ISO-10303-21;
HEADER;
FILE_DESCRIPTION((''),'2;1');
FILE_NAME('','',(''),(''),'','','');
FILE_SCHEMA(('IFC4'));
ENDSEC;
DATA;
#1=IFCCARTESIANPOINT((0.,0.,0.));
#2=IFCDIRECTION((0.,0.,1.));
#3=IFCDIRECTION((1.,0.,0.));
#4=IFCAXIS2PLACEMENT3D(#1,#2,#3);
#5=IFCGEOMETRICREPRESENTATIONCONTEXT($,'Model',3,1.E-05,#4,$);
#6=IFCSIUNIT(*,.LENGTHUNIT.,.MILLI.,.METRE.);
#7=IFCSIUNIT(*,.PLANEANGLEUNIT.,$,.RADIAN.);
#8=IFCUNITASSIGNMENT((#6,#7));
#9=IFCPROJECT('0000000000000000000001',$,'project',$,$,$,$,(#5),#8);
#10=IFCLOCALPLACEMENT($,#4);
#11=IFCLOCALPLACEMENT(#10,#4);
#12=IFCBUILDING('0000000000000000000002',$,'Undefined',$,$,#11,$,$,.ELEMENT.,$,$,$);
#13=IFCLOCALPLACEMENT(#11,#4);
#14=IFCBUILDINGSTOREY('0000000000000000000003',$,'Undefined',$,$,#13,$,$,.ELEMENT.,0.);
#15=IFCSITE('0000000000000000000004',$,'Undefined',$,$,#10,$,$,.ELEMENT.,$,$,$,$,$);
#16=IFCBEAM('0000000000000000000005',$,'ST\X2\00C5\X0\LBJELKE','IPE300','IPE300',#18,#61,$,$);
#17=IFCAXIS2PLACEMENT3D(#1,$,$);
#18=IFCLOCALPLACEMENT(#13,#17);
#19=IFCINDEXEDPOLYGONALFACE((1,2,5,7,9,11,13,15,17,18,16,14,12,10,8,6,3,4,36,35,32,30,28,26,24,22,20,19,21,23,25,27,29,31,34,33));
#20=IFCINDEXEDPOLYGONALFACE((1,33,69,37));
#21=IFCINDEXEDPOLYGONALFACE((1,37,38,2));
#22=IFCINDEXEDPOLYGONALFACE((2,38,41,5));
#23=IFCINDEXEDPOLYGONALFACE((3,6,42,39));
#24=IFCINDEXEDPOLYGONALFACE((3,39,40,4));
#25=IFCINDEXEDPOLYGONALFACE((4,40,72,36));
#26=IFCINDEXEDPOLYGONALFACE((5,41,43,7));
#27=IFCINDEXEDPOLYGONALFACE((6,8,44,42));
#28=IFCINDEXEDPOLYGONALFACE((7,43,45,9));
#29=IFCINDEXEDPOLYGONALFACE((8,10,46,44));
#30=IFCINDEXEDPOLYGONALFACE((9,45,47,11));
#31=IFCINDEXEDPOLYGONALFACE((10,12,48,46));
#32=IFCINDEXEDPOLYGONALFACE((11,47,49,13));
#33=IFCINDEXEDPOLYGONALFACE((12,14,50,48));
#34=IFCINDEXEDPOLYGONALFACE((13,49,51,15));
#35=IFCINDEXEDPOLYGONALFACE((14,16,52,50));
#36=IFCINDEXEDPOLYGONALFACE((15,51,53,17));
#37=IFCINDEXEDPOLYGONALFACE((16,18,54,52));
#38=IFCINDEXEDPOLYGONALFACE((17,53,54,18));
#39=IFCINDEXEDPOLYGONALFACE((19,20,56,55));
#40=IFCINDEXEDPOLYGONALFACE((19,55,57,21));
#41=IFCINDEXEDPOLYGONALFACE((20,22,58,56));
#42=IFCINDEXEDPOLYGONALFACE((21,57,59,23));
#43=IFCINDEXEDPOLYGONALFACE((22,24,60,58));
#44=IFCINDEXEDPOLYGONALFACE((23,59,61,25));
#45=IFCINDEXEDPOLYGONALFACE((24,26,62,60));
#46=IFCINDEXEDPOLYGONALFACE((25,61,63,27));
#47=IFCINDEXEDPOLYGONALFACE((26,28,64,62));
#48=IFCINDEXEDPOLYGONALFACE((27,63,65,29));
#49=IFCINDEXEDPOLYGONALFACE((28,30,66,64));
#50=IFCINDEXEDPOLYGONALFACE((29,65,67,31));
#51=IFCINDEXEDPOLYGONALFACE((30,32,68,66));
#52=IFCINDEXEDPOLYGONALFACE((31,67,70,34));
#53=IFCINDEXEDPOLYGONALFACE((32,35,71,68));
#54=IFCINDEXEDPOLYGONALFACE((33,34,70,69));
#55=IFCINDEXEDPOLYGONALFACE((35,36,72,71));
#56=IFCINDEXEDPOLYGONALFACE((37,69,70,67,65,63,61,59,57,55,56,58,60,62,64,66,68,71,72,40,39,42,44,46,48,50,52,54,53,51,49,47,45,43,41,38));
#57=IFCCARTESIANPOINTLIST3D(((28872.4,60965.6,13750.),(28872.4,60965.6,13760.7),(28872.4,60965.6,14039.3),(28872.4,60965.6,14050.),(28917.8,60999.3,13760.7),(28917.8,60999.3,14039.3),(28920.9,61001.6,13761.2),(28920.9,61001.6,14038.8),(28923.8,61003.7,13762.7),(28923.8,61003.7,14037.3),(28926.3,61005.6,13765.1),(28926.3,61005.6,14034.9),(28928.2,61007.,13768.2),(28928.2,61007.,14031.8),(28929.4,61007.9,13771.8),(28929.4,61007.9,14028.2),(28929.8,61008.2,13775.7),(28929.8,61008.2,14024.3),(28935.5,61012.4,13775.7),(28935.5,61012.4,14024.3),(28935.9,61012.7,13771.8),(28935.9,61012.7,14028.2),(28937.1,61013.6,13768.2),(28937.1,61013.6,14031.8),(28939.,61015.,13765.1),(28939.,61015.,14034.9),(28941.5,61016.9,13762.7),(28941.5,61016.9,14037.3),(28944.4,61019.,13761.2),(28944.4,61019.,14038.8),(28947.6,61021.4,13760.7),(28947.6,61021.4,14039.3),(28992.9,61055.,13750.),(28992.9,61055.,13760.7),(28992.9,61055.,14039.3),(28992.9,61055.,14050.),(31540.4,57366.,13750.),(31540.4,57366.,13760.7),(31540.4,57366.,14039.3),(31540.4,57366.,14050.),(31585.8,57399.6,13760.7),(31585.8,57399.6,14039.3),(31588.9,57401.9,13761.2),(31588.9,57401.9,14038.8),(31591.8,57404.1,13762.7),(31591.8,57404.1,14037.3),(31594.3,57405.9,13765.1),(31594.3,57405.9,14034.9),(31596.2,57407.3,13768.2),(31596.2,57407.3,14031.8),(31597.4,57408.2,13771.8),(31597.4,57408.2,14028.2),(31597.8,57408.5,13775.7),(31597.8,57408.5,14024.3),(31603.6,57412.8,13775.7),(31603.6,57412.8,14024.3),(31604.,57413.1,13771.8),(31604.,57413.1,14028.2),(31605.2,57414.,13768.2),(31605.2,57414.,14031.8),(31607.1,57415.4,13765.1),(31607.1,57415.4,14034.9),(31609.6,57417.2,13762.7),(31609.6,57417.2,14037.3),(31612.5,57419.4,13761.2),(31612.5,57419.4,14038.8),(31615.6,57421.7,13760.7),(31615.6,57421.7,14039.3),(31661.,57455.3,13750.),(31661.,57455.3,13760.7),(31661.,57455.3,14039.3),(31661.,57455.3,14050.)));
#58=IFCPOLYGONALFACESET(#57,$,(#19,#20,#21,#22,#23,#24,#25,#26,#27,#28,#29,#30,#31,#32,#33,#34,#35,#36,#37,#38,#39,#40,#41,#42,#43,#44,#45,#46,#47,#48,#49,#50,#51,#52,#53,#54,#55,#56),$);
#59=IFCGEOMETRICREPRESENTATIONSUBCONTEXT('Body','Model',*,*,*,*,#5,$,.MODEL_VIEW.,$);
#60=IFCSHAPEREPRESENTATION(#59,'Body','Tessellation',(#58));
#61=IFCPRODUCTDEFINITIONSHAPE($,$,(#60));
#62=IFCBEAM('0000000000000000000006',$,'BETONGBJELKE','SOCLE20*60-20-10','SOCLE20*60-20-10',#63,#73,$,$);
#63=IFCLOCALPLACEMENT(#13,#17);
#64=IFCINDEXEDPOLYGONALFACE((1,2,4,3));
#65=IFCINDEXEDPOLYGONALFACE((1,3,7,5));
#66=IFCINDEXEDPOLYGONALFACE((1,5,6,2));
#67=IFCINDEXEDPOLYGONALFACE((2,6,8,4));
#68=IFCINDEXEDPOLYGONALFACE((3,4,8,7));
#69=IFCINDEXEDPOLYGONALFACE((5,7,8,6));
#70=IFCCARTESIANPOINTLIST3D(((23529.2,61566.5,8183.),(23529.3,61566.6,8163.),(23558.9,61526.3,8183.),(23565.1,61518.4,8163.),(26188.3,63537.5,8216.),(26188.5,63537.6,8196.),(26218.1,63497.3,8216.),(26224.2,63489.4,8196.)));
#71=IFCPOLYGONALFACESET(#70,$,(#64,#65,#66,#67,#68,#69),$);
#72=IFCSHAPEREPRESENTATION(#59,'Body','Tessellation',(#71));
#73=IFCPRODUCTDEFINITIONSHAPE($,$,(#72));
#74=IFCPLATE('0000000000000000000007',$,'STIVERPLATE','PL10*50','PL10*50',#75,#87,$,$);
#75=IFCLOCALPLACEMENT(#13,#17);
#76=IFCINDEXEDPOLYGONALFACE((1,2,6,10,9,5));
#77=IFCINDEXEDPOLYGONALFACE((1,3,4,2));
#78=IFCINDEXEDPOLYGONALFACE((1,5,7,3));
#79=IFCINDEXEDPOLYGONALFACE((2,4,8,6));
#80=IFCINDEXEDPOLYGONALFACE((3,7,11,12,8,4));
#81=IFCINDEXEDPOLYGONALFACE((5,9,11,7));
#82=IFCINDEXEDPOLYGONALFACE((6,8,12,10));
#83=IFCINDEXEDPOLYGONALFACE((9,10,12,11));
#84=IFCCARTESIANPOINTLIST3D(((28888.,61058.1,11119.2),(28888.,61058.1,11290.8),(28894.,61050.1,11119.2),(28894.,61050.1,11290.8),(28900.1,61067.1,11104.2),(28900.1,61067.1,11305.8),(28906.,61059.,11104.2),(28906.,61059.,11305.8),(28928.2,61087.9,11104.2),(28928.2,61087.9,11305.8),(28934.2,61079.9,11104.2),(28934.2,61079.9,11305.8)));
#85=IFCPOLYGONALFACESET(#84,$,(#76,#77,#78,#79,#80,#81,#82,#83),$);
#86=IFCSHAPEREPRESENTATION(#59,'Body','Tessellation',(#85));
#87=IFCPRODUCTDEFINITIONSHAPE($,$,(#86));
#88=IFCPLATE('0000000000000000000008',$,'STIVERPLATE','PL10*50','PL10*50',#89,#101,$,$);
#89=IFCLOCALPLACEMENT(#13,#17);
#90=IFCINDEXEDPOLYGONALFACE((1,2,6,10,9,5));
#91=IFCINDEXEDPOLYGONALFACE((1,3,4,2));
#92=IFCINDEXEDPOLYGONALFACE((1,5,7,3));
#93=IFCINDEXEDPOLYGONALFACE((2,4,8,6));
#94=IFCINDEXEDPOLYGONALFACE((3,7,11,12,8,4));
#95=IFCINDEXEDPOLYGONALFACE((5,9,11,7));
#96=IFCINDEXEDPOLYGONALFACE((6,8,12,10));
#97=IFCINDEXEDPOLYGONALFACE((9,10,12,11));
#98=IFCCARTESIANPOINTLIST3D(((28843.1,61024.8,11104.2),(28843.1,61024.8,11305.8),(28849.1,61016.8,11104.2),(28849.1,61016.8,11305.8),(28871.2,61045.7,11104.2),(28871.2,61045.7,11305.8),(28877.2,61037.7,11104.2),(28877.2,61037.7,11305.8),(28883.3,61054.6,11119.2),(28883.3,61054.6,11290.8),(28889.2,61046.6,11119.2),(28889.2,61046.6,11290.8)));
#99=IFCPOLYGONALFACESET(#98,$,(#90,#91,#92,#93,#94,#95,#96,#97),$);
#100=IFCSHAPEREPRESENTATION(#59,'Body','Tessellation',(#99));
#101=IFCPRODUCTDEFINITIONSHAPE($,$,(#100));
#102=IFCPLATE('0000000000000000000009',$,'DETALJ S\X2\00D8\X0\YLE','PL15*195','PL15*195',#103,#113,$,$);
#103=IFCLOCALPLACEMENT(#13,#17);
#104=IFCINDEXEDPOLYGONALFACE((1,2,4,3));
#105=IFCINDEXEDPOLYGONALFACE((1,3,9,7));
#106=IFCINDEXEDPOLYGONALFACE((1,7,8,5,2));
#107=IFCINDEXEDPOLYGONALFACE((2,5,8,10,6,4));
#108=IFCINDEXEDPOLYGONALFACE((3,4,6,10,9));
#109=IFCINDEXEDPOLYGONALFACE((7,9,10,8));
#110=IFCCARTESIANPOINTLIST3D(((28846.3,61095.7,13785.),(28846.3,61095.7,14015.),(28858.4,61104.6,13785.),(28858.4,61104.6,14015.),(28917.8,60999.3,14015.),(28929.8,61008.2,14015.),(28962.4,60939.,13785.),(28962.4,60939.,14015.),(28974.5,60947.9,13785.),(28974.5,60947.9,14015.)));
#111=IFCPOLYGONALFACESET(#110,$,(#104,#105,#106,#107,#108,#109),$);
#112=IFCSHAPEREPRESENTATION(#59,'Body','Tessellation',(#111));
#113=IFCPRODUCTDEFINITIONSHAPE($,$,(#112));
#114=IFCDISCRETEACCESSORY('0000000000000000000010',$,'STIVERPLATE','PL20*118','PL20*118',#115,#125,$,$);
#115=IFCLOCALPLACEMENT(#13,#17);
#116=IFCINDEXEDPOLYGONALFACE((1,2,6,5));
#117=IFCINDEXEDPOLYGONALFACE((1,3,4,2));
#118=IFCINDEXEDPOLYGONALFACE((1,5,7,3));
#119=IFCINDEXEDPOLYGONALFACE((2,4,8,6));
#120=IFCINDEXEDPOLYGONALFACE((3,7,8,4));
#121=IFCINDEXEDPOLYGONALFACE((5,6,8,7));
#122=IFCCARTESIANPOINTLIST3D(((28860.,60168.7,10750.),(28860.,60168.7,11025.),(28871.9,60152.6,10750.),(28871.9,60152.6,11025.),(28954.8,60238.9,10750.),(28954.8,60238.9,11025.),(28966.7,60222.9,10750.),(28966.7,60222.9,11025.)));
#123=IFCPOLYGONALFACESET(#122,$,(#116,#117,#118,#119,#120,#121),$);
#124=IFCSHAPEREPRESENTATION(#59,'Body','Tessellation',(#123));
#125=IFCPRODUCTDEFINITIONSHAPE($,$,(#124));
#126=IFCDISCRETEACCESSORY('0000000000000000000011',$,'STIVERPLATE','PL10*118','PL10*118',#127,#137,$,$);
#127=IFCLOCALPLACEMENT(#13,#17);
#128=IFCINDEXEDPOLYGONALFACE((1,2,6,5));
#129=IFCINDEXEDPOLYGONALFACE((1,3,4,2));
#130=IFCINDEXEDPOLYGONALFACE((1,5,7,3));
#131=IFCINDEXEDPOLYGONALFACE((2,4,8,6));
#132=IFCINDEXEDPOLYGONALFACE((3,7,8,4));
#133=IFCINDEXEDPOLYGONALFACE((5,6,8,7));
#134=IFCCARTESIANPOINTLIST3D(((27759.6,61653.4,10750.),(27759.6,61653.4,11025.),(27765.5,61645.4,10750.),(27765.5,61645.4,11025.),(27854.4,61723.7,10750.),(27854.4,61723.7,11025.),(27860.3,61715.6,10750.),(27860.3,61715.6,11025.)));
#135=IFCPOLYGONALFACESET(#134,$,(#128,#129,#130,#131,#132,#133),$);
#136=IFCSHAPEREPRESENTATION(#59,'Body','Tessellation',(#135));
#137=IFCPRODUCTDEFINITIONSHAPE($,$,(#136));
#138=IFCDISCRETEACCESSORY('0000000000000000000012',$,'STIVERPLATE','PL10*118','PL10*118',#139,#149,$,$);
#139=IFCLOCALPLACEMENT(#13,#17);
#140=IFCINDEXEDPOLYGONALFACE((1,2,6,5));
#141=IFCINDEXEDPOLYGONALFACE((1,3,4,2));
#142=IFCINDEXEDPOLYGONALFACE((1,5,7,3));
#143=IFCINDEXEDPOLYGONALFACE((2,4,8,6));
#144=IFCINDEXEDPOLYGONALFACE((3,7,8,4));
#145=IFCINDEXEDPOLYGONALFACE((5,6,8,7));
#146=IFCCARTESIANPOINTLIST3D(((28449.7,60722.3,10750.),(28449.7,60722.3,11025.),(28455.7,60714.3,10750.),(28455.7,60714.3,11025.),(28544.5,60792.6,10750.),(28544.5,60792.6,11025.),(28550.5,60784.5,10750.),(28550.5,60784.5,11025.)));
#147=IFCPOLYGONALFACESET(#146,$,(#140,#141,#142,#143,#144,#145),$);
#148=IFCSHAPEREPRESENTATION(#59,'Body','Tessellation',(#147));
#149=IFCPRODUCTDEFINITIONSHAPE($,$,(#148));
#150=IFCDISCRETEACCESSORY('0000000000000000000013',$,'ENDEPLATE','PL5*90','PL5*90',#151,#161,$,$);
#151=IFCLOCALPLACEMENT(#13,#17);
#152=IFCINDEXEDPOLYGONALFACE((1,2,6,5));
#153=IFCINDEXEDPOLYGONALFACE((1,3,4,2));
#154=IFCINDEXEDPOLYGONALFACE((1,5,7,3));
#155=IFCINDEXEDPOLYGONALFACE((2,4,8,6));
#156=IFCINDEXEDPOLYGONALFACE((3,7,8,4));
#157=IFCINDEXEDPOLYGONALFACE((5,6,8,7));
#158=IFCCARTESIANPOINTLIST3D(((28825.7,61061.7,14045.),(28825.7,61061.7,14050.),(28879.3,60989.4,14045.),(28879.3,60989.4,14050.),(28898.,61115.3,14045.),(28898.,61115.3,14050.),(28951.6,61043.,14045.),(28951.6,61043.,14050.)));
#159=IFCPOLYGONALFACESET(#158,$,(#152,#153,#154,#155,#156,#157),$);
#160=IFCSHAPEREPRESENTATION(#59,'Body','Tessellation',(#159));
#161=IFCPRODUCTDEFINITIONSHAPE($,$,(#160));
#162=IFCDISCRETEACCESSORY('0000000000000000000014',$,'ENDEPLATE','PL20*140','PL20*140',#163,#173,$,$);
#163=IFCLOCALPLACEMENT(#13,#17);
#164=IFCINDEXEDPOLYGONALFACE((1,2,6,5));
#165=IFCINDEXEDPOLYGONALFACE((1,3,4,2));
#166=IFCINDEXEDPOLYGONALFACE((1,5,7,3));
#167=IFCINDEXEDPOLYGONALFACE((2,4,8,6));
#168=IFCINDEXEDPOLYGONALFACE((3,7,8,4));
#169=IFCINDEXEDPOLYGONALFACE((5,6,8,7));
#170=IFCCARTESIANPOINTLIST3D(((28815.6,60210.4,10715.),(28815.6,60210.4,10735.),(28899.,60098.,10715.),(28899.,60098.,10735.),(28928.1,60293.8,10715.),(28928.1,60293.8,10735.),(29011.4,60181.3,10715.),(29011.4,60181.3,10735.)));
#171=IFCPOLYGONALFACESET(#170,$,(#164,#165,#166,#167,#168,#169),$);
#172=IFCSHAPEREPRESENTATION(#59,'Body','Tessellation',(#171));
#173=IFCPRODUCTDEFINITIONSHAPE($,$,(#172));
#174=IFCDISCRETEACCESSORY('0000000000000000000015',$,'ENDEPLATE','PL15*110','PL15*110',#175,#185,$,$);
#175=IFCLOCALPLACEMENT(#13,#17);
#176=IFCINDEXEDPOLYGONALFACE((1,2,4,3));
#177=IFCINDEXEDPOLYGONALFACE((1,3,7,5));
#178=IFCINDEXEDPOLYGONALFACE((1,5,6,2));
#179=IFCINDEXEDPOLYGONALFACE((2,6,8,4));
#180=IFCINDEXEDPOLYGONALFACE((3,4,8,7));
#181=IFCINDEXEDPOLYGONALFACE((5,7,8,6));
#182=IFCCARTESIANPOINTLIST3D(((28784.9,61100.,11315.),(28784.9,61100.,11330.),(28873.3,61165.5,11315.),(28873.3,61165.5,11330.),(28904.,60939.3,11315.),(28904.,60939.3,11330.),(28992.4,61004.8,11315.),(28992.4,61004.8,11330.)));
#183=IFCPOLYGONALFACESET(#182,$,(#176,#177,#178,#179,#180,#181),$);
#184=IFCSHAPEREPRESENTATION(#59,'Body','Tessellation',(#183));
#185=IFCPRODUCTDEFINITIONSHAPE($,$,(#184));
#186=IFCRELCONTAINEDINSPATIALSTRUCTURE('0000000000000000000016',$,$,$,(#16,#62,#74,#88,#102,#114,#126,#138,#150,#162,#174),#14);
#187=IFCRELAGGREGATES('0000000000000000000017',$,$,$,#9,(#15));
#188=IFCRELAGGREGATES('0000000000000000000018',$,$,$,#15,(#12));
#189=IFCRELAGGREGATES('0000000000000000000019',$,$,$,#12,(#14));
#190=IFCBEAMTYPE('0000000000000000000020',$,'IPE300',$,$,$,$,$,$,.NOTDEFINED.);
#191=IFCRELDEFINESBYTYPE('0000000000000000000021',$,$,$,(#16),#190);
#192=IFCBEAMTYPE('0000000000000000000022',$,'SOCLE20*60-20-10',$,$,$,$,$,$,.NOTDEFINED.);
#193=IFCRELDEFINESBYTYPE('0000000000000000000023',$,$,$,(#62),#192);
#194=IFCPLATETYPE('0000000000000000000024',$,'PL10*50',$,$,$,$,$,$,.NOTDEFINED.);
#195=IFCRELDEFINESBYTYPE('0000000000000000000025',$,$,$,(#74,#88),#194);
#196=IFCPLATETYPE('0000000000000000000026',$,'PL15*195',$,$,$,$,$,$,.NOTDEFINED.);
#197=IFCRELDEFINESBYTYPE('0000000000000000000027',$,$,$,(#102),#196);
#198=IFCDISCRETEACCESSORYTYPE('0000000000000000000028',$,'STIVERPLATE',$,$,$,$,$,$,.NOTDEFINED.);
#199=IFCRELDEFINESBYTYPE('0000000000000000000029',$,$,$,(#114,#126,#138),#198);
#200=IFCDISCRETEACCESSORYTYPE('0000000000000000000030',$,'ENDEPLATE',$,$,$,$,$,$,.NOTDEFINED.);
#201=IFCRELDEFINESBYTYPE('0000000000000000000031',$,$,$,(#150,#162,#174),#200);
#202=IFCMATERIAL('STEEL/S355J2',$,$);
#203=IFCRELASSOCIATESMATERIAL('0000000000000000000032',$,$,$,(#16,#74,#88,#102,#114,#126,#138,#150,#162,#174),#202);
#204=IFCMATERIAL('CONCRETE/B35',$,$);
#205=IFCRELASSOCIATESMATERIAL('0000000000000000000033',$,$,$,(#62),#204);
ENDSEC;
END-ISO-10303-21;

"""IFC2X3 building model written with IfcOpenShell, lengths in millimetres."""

from ifc_helpers import new_model, si_unit, frame, origin_with_axes, origin_2d_with_axis, place, context, subcontext, project, spatial, polyline, i_section, outline, extrude, clip, halfspace, material, type_object, element, save


model = new_model("IFC2X3")

# Units and contexts
model_context = context("Model", 3, precision=1e-05, world=origin_with_axes())
body_context = subcontext(model_context, "Body", "Model", "MODEL_VIEW")
ifc_project = project(units=[si_unit("LENGTHUNIT", "METRE", prefix="MILLI"), si_unit("PLANEANGLEUNIT", "RADIAN")], contexts=[model_context])

# Site, building, storey
site_placement = place(None, origin_with_axes())
site = spatial("IfcSite", under=ifc_project, at=site_placement, Name="Undefined", CompositionType="ELEMENT")
building_placement = place(site_placement, origin_with_axes())
building = spatial("IfcBuilding", under=site, at=building_placement, Name="Undefined", CompositionType="ELEMENT")
storey_placement = place(building_placement, origin_with_axes())
storey = spatial("IfcBuildingStorey", under=building, at=storey_placement, Name="Undefined", CompositionType="ELEMENT", Elevation=0.0)

# Shared definitions
ifc_material_1 = material(Name="STEEL/S355J2")

# Beams
beam_type_1 = type_object("IfcBeamType", Name="IPE300", PredefinedType="NOTDEFINED")
beam_1_placement = place(storey_placement, frame((28926.7, 61018.3, 13900.0), z_axis=(0.0, 0.0, 1.0), x_axis=(0.595461, -0.803384, 0.0)))
element("IfcBeam", 1, at=beam_1_placement, inside=storey, type_object=beam_type_1, material=ifc_material_1, Name="STÅLBJELKE", Description="IPE300", ObjectType="IPE300", context=body_context, shape_type="Clipping", body=[
    clip(clip(extrude(i_section(OverallWidth=150.0, OverallDepth=300.0, WebThickness=7.1, FlangeThickness=10.7, FilletRadius=15.0, at=origin_2d_with_axis()), frame((4635.6, 0.0, 0.0), z_axis=(-1.0, 0.0, 0.0), x_axis=(0.0, -1.0, 0.0)), (0.0, 0.0, 1.0), 4770.5), halfspace(frame((4490.6, 0.0, 250.0), z_axis=(1.0, -0.00002, 0.0), x_axis=(0.00002, 1.0, 0.0)), False)), halfspace(frame((10.0, 0.0, 250.0), z_axis=(-1.0, 0.00002, 0.0), x_axis=(-0.00002, -1.0, 0.0)), False)),
])
ifc_material_2 = material(Name="CONCRETE/B35")
beam_type_2 = type_object("IfcBeamType", Name="SOCLE20*60-20-10", PredefinedType="NOTDEFINED")
beam_2_placement = place(storey_placement, frame((23547.1, 61542.4, 8173.0), z_axis=(-0.008009, -0.005937, 0.99995), x_axis=(0.803328, 0.595453, 0.009969)))
element("IfcBeam", 2, at=beam_2_placement, inside=storey, type_object=beam_type_2, material=ifc_material_2, Name="BETONGBJELKE", Description="SOCLE20*60-20-10", ObjectType="SOCLE20*60-20-10", context=body_context, shape_type="SweptSolid", body=[
    extrude(outline(polyline([(30.0, -10.0), (-30.0, -10.0), (-30.0, 10.0), (20.0, 10.0), (30.0, -10.0)])), frame((3310.2, 0.0, 0.0), z_axis=(-1.0, 0.0, 0.0), x_axis=(0.0, -1.0, 0.0)), (0.0, 0.0, 1.0), 3310.2),
])

# Plates
plate_type_1 = type_object("IfcPlateType", Name="PL10*50", PredefinedType="NOTDEFINED")
plate_1_placement = place(storey_placement, frame((28931.2, 61083.9, 11104.2), z_axis=(-0.595472, 0.803376, 0.0), x_axis=(-0.803376, -0.595472, 0.0)))
element("IfcPlate", 3, at=plate_1_placement, inside=storey, type_object=plate_type_1, material=ifc_material_1, Name="STIVERPLATE", Description="PL10*50", ObjectType="PL10*50", context=body_context, shape_type="SweptSolid", body=[
    extrude(outline(polyline([(0.0, 0.0), (35.0, 0.0), (50.0, 15.0), (50.0, 186.6), (35.0, 201.6), (0.0, 201.6), (0.0, 0.0)])), frame((0.0, 0.0, -5.0), z_axis=(0.0, 0.0, 1.0), x_axis=(1.0, 0.0, 0.0)), (0.0, 0.0, 1.0), 10.0),
])
plate_2_placement = place(storey_placement, frame((28886.3, 61050.6, 11104.2), z_axis=(-0.595472, 0.803376, 0.0), x_axis=(-0.803376, -0.595472, 0.0)))
element("IfcPlate", 4, at=plate_2_placement, inside=storey, type_object=plate_type_1, material=ifc_material_1, Name="STIVERPLATE", Description="PL10*50", ObjectType="PL10*50", context=body_context, shape_type="SweptSolid", body=[
    extrude(outline(polyline([(0.0, 15.0), (15.0, 0.0), (50.0, 0.0), (50.0, 201.6), (15.0, 201.6), (0.0, 186.6), (0.0, 15.0)])), frame((0.0, 0.0, -5.0), z_axis=(0.0, 0.0, 1.0), x_axis=(1.0, 0.0, 0.0)), (0.0, 0.0, 1.0), 10.0),
])
plate_type_2 = type_object("IfcPlateType", Name="PL15*195", PredefinedType="NOTDEFINED")
plate_3_placement = place(storey_placement, frame((28923.8, 61003.7, 14015.0), z_axis=(-0.803384, -0.595461, 0.0), x_axis=(-0.595461, 0.803384, 0.0)))
element("IfcPlate", 5, at=plate_3_placement, inside=storey, type_object=plate_type_2, material=ifc_material_1, Name="DETALJ SØYLE", Description="PL15*195", ObjectType="PL15*195", context=body_context, shape_type="SweptSolid", body=[
    extrude(outline(polyline([(0.0, 0.0), (120.0, 0.0), (120.0, 230.0), (-75.0, 230.0), (-75.0, 0.0), (0.0, 0.0)])), frame((0.0, 0.0, -7.5), z_axis=(0.0, 0.0, 1.0), x_axis=(1.0, 0.0, 0.0)), (0.0, 0.0, 1.0), 15.0),
])

# Discrete accessories
discrete_accessory_type_1 = type_object("IfcDiscreteAccessoryType", Name="STIVERPLATE")
discrete_accessory_1_placement = place(storey_placement, frame((28913.4, 60195.8, 10750.0), z_axis=(0.595444, -0.803397, 0.0), x_axis=(0.0, 0.0, 1.0)))
element("IfcDiscreteAccessory", 6, at=discrete_accessory_1_placement, inside=storey, type_object=discrete_accessory_type_1, material=ifc_material_1, Name="STIVERPLATE", Description="PL20*118", ObjectType="PL20*118", context=body_context, shape_type="SweptSolid", body=[
    extrude(outline(polyline([(0.0, 59.0), (275.0, 59.0), (275.0, -59.0), (0.0, -59.0), (0.0, 59.0)])), frame((0.0, 0.0, -10.0), z_axis=(0.0, 0.0, 1.0), x_axis=(1.0, 0.0, 0.0)), (0.0, 0.0, 1.0), 20.0),
])
for number, where, z_axis, x_axis, name in (
    (7, (27810.0, 61684.5, 10750.0), (0.595444, -0.803397, 0.0), (0.0, 0.0, 1.0), "STIVERPLATE"),
    (8, (28500.1, 60753.4, 10750.0), (0.595444, -0.803397, 0.0), (0.0, 0.0, 1.0), "STIVERPLATE"),
):
    element("IfcDiscreteAccessory", number, at=place(storey_placement, frame(where, z_axis=z_axis, x_axis=x_axis)), inside=storey, type_object=discrete_accessory_type_1, material=ifc_material_1, Name=name, Description="PL10*118", ObjectType="PL10*118", context=body_context, shape_type="SweptSolid", body=[
        extrude(outline(polyline([(0.0, 59.0), (275.0, 59.0), (275.0, -59.0), (0.0, -59.0), (0.0, 59.0)])), frame((0.0, 0.0, -5.0), z_axis=(0.0, 0.0, 1.0), x_axis=(1.0, 0.0, 0.0)), (0.0, 0.0, 1.0), 10.0),
    ])
discrete_accessory_type_2 = type_object("IfcDiscreteAccessoryType", Name="ENDEPLATE")
discrete_accessory_2_placement = place(storey_placement, frame((28915.4, 61016.2, 14047.5), z_axis=(0.0, 0.0, -1.0), x_axis=(-0.595445, 0.803396, 0.0)))
element("IfcDiscreteAccessory", 9, at=discrete_accessory_2_placement, inside=storey, type_object=discrete_accessory_type_2, material=ifc_material_1, Name="ENDEPLATE", Description="PL5*90", ObjectType="PL5*90", context=body_context, shape_type="SweptSolid", body=[
    extrude(outline(polyline([(90.0, -45.0), (0.0, -45.0), (0.0, 45.0), (90.0, 45.0), (90.0, -45.0)])), frame((0.0, 0.0, -2.5), z_axis=(0.0, 0.0, 1.0), x_axis=(1.0, 0.0, 0.0)), (0.0, 0.0, 1.0), 5.0),
])
discrete_accessory_3_placement = place(storey_placement, frame((28871.8, 60252.1, 10725.0), z_axis=(0.0, 0.0, -1.0), x_axis=(0.595445, -0.803396, 0.0)))
element("IfcDiscreteAccessory", 10, at=discrete_accessory_3_placement, inside=storey, type_object=discrete_accessory_type_2, material=ifc_material_1, Name="ENDEPLATE", Description="PL20*140", ObjectType="PL20*140", context=body_context, shape_type="SweptSolid", body=[
    extrude(outline(polyline([(0.0, 70.0), (140.0, 70.0), (140.0, -70.0), (0.0, -70.0), (0.0, 70.0)])), frame((0.0, 0.0, -10.0), z_axis=(0.0, 0.0, 1.0), x_axis=(1.0, 0.0, 0.0)), (0.0, 0.0, 1.0), 20.0),
])
discrete_accessory_4_placement = place(storey_placement, frame((28948.2, 60972.0, 11322.5), z_axis=(0.0, 0.0, 1.0), x_axis=(-0.595445, 0.803396, 0.0)))
element("IfcDiscreteAccessory", 11, at=discrete_accessory_4_placement, inside=storey, type_object=discrete_accessory_type_2, material=ifc_material_1, Name="ENDEPLATE", Description="PL15*110", ObjectType="PL15*110", context=body_context, shape_type="SweptSolid", body=[
    extrude(outline(polyline([(200.0, 55.0), (200.0, -55.0), (0.0, -55.0), (0.0, 55.0), (200.0, 55.0)])), frame((0.0, 0.0, -7.5), z_axis=(0.0, 0.0, 1.0), x_axis=(1.0, 0.0, 0.0)), (0.0, 0.0, 1.0), 15.0),
])

save(model, "model.ifc")
